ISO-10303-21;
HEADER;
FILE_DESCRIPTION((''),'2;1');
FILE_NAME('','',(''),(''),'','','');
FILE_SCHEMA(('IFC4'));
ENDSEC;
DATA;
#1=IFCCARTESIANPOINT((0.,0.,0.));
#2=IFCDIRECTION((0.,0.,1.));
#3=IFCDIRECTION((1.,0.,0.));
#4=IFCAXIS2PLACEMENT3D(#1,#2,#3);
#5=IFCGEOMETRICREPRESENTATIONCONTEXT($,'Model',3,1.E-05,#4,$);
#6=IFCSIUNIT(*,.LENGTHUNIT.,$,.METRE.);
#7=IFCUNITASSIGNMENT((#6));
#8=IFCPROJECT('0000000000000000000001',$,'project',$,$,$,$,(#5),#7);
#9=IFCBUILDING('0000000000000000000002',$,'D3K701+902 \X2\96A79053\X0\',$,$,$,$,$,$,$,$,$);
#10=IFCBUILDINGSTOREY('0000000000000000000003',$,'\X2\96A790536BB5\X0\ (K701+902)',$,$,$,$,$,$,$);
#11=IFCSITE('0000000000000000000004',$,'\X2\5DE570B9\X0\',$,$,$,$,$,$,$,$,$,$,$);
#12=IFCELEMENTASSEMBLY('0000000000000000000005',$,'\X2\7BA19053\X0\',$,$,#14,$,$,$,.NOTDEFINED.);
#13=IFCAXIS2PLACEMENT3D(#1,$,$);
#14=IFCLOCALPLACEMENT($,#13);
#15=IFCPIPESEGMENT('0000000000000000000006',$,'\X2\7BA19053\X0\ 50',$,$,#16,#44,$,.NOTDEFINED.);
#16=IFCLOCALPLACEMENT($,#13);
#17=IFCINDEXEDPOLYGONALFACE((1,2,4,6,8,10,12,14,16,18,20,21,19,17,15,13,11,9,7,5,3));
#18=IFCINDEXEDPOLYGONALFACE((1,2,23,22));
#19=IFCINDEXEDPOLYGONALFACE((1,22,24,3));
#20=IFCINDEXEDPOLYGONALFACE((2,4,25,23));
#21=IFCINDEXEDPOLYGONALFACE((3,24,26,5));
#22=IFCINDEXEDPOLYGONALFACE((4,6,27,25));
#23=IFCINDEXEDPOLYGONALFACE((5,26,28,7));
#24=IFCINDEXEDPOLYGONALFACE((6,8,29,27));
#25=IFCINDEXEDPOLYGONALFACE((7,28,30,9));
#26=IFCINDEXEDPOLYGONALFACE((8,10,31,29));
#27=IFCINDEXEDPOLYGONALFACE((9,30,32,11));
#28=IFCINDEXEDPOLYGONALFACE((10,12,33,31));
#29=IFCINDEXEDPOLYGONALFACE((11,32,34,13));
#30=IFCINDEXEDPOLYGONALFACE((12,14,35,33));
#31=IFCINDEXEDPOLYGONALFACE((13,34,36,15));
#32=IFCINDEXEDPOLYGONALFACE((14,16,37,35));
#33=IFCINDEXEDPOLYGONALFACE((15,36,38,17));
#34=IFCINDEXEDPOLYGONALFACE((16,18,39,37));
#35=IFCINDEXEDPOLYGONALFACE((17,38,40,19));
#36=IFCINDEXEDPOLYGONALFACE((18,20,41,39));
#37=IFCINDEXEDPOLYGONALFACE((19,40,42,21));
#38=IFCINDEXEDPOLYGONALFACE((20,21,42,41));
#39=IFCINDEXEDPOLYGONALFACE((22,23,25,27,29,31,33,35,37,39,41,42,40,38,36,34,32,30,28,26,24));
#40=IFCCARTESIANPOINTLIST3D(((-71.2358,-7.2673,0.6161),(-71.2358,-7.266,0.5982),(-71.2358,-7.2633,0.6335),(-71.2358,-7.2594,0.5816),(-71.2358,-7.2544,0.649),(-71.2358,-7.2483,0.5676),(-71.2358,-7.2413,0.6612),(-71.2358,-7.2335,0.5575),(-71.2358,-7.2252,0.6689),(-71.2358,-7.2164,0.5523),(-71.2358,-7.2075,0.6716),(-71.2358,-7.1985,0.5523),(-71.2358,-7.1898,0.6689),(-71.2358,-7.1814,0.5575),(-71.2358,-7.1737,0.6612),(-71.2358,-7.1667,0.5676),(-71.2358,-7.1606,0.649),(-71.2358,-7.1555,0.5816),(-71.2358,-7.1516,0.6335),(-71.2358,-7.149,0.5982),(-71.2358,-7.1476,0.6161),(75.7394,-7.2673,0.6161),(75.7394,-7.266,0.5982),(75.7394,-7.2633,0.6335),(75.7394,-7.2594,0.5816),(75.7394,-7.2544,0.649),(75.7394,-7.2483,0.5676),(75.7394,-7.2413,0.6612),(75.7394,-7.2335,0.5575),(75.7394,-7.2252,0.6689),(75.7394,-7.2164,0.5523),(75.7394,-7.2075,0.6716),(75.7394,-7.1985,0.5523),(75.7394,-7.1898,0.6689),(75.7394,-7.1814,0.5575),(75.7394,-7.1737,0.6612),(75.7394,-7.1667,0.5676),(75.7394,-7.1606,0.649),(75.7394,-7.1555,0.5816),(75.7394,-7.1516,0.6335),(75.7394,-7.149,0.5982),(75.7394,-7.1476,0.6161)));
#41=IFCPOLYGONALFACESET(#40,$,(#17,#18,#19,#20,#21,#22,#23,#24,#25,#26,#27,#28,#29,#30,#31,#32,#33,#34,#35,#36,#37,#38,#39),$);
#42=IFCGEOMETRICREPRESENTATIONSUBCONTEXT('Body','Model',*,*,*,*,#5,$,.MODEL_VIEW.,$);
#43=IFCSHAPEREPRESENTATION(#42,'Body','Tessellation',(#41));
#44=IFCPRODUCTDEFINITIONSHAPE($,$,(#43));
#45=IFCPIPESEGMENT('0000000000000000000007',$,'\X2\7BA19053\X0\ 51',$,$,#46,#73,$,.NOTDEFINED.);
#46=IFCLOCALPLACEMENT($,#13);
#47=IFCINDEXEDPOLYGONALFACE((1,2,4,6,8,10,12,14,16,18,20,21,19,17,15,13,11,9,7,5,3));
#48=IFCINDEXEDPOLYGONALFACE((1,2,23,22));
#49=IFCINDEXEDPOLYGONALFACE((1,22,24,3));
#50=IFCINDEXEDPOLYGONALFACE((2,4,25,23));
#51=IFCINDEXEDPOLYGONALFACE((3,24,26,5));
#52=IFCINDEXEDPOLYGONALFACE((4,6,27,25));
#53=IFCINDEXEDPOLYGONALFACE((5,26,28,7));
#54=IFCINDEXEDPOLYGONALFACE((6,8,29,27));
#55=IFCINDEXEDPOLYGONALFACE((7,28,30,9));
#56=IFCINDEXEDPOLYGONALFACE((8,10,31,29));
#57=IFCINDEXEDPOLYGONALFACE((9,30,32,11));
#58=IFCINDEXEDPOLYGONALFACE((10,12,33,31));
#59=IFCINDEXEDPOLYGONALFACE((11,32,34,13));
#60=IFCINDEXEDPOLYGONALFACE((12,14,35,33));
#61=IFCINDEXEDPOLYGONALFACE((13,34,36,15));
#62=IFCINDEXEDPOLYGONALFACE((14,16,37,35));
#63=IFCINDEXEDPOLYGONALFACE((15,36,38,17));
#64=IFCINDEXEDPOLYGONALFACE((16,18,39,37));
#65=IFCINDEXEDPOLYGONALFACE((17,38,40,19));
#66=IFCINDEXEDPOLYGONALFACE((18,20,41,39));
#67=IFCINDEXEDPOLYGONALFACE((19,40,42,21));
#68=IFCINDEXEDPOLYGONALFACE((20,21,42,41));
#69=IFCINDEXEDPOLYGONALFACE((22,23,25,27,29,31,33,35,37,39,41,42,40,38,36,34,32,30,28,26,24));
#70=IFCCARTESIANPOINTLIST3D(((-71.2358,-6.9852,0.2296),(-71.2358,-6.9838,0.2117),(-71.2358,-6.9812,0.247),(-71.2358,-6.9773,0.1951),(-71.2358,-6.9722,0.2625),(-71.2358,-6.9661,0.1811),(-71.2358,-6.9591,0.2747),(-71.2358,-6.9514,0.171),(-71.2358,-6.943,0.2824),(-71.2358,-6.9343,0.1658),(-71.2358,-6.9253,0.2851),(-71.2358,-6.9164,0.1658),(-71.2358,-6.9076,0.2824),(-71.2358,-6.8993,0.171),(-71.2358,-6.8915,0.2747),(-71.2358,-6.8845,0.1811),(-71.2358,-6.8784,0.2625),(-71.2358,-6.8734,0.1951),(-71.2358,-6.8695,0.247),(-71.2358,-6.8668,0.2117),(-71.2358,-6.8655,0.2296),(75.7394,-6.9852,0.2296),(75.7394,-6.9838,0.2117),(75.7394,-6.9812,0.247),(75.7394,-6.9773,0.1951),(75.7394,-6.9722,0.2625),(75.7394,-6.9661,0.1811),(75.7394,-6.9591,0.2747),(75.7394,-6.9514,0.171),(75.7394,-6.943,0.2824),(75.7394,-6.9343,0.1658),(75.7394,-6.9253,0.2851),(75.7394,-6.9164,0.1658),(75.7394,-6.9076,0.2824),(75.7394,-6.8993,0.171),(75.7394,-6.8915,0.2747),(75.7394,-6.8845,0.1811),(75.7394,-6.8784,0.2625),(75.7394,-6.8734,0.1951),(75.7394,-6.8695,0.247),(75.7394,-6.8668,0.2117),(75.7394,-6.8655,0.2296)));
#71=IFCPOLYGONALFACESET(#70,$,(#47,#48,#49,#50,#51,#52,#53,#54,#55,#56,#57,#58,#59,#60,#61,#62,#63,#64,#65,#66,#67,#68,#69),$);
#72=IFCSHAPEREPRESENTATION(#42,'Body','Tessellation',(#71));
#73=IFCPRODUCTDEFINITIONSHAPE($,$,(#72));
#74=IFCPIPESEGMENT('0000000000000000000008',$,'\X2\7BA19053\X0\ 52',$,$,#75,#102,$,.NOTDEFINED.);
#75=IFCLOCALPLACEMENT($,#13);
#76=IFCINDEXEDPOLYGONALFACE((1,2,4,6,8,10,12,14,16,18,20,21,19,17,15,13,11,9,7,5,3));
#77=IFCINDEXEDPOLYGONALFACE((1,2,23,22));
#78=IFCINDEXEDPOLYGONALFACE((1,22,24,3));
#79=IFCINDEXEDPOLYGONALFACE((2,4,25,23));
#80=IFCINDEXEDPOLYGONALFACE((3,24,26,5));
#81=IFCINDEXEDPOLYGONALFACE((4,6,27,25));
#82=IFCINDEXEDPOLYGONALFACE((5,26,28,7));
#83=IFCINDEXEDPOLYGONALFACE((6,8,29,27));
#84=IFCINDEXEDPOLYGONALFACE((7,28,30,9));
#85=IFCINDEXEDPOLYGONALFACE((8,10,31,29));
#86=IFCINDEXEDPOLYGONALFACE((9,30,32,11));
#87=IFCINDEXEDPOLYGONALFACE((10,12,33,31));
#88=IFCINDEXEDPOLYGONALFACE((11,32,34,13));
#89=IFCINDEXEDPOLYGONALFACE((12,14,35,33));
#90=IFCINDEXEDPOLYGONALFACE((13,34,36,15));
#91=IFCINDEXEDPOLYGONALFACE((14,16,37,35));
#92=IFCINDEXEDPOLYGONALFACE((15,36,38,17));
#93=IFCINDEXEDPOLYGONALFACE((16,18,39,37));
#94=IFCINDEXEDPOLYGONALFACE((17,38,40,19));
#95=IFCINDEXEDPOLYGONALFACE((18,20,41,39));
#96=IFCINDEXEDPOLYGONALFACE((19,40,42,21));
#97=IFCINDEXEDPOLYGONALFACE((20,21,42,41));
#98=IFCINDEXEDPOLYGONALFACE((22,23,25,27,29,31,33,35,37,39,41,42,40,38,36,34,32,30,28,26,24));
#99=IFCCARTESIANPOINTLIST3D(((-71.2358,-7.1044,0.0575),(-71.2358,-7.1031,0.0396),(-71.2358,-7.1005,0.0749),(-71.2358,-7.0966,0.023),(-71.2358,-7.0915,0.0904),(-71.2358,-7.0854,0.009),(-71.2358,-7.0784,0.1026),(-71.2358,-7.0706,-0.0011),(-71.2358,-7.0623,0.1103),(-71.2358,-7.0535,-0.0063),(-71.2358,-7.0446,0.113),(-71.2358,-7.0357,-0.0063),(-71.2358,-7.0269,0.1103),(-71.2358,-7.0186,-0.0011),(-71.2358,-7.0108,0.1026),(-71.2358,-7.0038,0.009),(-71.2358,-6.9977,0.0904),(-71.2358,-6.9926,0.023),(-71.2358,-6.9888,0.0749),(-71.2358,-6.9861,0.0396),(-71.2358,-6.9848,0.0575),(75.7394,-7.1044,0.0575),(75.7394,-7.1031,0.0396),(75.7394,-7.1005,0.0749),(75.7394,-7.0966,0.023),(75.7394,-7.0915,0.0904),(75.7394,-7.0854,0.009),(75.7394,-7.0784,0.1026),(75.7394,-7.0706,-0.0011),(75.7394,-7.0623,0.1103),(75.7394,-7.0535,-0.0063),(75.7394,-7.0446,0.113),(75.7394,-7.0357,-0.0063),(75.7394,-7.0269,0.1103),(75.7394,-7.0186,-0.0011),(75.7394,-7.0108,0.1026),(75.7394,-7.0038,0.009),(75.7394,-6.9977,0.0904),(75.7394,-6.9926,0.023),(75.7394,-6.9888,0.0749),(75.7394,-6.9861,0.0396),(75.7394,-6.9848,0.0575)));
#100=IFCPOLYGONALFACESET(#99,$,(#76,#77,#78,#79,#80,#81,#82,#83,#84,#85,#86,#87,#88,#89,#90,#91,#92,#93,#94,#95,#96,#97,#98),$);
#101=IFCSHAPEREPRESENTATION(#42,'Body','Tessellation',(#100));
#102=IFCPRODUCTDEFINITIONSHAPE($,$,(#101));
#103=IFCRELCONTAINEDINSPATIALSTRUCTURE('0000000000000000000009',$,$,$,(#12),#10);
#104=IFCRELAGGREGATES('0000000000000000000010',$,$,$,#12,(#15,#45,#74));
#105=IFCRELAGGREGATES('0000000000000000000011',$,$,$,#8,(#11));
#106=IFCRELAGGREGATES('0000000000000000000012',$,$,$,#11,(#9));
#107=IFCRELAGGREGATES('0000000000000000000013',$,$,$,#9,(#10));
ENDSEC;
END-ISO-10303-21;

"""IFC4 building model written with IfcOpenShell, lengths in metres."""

from ifc_helpers import new_model, entity, si_unit, origin_with_axes, context, subcontext, project, spatial, element, aggregate, save


model = new_model("IFC4")

# Units and contexts
model_context = context("Model", 3, precision=1e-05, world=origin_with_axes())
body_context = subcontext(model_context, "Body", "Model", "MODEL_VIEW")
ifc_project = project(units=[si_unit("LENGTHUNIT", "METRE")], contexts=[model_context])

# Site, building, storey
site = spatial("IfcSite", under=ifc_project, Name="工点")
building = spatial("IfcBuilding", under=site, Name="D3K701+902 隧道")
storey = spatial("IfcBuildingStorey", under=building, Name="隧道段 (K701+902)")

# Element assembly, pipe segments
assembly_1 = element("IfcElementAssembly", 1, inside=storey, Name="管道", PredefinedType="NOTDEFINED")
pipe_segment_1 = element("IfcPipeSegment", 2, Name="管道 50", PredefinedType="NOTDEFINED", context=body_context, shape_type="SweptSolid", body=[
    entity("IfcSweptDiskSolid", entity("IfcPolyline", [entity("IfcCartesianPoint", [-71.2358, -7.2075, 0.6116]), entity("IfcCartesianPoint", [75.7394, -7.2075, 0.6116])]), 0.06),
])
pipe_segment_2 = element("IfcPipeSegment", 3, Name="管道 51", PredefinedType="NOTDEFINED", context=body_context, shape_type="SweptSolid", body=[
    entity("IfcSweptDiskSolid", entity("IfcPolyline", [entity("IfcCartesianPoint", [-71.2358, -6.9253, 0.2251]), entity("IfcCartesianPoint", [75.7394, -6.9253, 0.2251])]), 0.06),
])
pipe_segment_3 = element("IfcPipeSegment", 4, Name="管道 52", PredefinedType="NOTDEFINED", context=body_context, shape_type="SweptSolid", body=[
    entity("IfcSweptDiskSolid", entity("IfcPolyline", [entity("IfcCartesianPoint", [-71.2358, -7.0446, 0.053]), entity("IfcCartesianPoint", [75.7394, -7.0446, 0.053])]), 0.06),
])
aggregate(assembly_1, [pipe_segment_1, pipe_segment_2, pipe_segment_3])

save(model, "model.ifc")
